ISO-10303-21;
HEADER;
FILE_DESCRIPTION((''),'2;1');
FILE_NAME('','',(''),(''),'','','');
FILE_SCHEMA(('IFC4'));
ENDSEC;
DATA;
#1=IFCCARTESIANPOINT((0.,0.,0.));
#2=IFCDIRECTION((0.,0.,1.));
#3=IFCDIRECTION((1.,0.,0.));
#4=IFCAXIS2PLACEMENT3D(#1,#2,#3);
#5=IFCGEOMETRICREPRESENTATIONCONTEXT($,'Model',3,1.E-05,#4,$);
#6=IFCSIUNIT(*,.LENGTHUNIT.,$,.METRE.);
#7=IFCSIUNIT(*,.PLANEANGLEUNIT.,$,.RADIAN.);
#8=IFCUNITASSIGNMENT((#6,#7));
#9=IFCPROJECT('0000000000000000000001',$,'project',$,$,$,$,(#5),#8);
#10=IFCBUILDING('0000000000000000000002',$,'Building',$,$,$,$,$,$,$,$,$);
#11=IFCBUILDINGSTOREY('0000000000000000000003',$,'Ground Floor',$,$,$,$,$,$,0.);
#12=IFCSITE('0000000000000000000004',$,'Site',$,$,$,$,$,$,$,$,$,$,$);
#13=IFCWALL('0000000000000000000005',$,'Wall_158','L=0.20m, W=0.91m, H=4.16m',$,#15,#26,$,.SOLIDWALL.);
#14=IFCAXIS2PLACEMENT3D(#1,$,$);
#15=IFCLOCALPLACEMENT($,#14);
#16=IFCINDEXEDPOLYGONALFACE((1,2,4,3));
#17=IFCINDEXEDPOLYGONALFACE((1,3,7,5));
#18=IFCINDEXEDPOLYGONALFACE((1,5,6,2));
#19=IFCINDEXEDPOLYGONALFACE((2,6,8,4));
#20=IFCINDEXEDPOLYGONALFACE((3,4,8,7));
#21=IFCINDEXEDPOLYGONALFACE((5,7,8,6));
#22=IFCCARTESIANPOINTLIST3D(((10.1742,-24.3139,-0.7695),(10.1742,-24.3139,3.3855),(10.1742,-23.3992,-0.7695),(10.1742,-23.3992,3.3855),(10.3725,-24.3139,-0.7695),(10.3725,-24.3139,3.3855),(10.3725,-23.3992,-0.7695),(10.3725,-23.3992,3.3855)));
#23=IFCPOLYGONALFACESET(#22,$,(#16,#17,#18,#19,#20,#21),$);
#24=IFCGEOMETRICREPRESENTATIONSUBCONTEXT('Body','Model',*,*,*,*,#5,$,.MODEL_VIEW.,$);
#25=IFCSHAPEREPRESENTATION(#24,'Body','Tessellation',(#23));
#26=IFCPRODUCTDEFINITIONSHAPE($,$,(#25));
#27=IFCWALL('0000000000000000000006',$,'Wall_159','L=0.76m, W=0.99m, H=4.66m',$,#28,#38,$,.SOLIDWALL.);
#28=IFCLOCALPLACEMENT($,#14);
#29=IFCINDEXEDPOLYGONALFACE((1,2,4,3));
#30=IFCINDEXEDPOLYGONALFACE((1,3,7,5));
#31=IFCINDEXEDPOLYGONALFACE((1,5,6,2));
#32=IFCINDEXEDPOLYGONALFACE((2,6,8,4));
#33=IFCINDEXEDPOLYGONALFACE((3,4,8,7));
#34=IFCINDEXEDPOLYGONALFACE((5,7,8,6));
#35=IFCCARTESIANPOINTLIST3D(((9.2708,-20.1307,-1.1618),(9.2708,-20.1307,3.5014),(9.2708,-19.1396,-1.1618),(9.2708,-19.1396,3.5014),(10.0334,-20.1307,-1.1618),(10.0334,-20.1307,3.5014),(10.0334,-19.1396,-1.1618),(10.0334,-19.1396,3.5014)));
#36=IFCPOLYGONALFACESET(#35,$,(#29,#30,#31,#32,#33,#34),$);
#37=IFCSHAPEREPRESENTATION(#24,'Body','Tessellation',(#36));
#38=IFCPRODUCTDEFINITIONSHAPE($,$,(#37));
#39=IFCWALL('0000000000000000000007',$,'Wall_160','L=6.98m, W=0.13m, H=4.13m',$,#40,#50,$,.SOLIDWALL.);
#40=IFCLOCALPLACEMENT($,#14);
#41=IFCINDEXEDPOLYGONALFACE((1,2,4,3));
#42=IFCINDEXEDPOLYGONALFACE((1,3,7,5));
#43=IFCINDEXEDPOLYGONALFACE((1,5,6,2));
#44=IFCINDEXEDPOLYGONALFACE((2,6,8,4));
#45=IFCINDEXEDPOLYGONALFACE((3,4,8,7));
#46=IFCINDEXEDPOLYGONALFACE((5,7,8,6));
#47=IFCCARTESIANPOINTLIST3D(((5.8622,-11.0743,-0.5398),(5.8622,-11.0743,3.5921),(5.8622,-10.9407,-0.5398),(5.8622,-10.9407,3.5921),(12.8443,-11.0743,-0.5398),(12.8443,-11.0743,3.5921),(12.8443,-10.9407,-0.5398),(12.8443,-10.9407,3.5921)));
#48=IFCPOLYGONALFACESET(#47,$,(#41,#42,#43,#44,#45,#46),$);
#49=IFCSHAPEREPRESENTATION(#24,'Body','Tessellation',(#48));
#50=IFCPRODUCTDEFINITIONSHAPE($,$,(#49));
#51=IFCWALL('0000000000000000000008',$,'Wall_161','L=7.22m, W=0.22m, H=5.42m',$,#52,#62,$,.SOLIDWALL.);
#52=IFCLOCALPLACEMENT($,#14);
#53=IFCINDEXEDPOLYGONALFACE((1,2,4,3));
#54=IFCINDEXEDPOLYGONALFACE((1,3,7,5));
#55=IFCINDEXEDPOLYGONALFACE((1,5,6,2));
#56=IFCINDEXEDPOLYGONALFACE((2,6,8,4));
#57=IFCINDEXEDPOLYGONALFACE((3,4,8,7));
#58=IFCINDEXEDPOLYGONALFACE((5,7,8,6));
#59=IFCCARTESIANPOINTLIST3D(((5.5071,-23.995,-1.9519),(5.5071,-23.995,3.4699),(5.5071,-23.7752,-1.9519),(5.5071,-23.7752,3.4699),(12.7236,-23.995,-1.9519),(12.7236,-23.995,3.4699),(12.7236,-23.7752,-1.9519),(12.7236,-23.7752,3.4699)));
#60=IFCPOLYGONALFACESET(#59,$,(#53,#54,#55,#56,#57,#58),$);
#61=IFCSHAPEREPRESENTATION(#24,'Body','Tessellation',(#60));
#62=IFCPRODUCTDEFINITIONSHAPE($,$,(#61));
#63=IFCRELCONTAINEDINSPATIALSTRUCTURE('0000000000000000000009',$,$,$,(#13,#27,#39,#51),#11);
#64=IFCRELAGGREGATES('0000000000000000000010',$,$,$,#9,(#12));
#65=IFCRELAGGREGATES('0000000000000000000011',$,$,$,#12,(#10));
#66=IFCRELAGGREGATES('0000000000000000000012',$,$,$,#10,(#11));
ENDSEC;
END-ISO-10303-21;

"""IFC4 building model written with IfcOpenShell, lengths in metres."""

from ifc_helpers import new_model, si_unit, frame, origin_with_axes, origin_2d, context, subcontext, project, spatial, rectangle, extrude, element, save


model = new_model("IFC4")

# Units and contexts
model_context = context("Model", 3, precision=1e-05, world=origin_with_axes())
body_context = subcontext(model_context, "Body", "Model", "MODEL_VIEW")
ifc_project = project(units=[si_unit("LENGTHUNIT", "METRE"), si_unit("PLANEANGLEUNIT", "RADIAN")], contexts=[model_context])

# Site, building, storey
site = spatial("IfcSite", under=ifc_project, Name="Site")
building = spatial("IfcBuilding", under=site, Name="Building")
storey = spatial("IfcBuildingStorey", under=building, Name="Ground Floor", Elevation=0.0)

# Walls
element("IfcWall", 1, inside=storey, Name="Wall_158", Description="L=0.20m, W=0.91m, H=4.16m", PredefinedType="SOLIDWALL", context=body_context, shape_type="SweptSolid", body=[
    extrude(rectangle(XDim=0.1983, YDim=0.9148, at=origin_2d()), frame((10.2733, -23.8565, -0.7695), z_axis=(0.0, 0.0, 1.0), x_axis=(1.0, 0.0, 0.0)), (0.0, 0.0, 1.0), 4.155),
])
element("IfcWall", 2, inside=storey, Name="Wall_159", Description="L=0.76m, W=0.99m, H=4.66m", PredefinedType="SOLIDWALL", context=body_context, shape_type="SweptSolid", body=[
    extrude(rectangle(XDim=0.7626, YDim=0.9911, at=origin_2d()), frame((9.6521, -19.6352, -1.1618), z_axis=(0.0, 0.0, 1.0), x_axis=(1.0, 0.0, 0.0)), (0.0, 0.0, 1.0), 4.6632),
])
element("IfcWall", 3, inside=storey, Name="Wall_160", Description="L=6.98m, W=0.13m, H=4.13m", PredefinedType="SOLIDWALL", context=body_context, shape_type="SweptSolid", body=[
    extrude(rectangle(XDim=6.9821, YDim=0.1337, at=origin_2d()), frame((9.3532, -11.0075, -0.5398), z_axis=(0.0, 0.0, 1.0), x_axis=(1.0, 0.0, 0.0)), (0.0, 0.0, 1.0), 4.132),
])
element("IfcWall", 4, inside=storey, Name="Wall_161", Description="L=7.22m, W=0.22m, H=5.42m", PredefinedType="SOLIDWALL", context=body_context, shape_type="SweptSolid", body=[
    extrude(rectangle(XDim=7.2165, YDim=0.2198, at=origin_2d()), frame((9.1153, -23.8851, -1.9519), z_axis=(0.0, 0.0, 1.0), x_axis=(1.0, 0.0, 0.0)), (0.0, 0.0, 1.0), 5.4218),
])

save(model, "model.ifc")
